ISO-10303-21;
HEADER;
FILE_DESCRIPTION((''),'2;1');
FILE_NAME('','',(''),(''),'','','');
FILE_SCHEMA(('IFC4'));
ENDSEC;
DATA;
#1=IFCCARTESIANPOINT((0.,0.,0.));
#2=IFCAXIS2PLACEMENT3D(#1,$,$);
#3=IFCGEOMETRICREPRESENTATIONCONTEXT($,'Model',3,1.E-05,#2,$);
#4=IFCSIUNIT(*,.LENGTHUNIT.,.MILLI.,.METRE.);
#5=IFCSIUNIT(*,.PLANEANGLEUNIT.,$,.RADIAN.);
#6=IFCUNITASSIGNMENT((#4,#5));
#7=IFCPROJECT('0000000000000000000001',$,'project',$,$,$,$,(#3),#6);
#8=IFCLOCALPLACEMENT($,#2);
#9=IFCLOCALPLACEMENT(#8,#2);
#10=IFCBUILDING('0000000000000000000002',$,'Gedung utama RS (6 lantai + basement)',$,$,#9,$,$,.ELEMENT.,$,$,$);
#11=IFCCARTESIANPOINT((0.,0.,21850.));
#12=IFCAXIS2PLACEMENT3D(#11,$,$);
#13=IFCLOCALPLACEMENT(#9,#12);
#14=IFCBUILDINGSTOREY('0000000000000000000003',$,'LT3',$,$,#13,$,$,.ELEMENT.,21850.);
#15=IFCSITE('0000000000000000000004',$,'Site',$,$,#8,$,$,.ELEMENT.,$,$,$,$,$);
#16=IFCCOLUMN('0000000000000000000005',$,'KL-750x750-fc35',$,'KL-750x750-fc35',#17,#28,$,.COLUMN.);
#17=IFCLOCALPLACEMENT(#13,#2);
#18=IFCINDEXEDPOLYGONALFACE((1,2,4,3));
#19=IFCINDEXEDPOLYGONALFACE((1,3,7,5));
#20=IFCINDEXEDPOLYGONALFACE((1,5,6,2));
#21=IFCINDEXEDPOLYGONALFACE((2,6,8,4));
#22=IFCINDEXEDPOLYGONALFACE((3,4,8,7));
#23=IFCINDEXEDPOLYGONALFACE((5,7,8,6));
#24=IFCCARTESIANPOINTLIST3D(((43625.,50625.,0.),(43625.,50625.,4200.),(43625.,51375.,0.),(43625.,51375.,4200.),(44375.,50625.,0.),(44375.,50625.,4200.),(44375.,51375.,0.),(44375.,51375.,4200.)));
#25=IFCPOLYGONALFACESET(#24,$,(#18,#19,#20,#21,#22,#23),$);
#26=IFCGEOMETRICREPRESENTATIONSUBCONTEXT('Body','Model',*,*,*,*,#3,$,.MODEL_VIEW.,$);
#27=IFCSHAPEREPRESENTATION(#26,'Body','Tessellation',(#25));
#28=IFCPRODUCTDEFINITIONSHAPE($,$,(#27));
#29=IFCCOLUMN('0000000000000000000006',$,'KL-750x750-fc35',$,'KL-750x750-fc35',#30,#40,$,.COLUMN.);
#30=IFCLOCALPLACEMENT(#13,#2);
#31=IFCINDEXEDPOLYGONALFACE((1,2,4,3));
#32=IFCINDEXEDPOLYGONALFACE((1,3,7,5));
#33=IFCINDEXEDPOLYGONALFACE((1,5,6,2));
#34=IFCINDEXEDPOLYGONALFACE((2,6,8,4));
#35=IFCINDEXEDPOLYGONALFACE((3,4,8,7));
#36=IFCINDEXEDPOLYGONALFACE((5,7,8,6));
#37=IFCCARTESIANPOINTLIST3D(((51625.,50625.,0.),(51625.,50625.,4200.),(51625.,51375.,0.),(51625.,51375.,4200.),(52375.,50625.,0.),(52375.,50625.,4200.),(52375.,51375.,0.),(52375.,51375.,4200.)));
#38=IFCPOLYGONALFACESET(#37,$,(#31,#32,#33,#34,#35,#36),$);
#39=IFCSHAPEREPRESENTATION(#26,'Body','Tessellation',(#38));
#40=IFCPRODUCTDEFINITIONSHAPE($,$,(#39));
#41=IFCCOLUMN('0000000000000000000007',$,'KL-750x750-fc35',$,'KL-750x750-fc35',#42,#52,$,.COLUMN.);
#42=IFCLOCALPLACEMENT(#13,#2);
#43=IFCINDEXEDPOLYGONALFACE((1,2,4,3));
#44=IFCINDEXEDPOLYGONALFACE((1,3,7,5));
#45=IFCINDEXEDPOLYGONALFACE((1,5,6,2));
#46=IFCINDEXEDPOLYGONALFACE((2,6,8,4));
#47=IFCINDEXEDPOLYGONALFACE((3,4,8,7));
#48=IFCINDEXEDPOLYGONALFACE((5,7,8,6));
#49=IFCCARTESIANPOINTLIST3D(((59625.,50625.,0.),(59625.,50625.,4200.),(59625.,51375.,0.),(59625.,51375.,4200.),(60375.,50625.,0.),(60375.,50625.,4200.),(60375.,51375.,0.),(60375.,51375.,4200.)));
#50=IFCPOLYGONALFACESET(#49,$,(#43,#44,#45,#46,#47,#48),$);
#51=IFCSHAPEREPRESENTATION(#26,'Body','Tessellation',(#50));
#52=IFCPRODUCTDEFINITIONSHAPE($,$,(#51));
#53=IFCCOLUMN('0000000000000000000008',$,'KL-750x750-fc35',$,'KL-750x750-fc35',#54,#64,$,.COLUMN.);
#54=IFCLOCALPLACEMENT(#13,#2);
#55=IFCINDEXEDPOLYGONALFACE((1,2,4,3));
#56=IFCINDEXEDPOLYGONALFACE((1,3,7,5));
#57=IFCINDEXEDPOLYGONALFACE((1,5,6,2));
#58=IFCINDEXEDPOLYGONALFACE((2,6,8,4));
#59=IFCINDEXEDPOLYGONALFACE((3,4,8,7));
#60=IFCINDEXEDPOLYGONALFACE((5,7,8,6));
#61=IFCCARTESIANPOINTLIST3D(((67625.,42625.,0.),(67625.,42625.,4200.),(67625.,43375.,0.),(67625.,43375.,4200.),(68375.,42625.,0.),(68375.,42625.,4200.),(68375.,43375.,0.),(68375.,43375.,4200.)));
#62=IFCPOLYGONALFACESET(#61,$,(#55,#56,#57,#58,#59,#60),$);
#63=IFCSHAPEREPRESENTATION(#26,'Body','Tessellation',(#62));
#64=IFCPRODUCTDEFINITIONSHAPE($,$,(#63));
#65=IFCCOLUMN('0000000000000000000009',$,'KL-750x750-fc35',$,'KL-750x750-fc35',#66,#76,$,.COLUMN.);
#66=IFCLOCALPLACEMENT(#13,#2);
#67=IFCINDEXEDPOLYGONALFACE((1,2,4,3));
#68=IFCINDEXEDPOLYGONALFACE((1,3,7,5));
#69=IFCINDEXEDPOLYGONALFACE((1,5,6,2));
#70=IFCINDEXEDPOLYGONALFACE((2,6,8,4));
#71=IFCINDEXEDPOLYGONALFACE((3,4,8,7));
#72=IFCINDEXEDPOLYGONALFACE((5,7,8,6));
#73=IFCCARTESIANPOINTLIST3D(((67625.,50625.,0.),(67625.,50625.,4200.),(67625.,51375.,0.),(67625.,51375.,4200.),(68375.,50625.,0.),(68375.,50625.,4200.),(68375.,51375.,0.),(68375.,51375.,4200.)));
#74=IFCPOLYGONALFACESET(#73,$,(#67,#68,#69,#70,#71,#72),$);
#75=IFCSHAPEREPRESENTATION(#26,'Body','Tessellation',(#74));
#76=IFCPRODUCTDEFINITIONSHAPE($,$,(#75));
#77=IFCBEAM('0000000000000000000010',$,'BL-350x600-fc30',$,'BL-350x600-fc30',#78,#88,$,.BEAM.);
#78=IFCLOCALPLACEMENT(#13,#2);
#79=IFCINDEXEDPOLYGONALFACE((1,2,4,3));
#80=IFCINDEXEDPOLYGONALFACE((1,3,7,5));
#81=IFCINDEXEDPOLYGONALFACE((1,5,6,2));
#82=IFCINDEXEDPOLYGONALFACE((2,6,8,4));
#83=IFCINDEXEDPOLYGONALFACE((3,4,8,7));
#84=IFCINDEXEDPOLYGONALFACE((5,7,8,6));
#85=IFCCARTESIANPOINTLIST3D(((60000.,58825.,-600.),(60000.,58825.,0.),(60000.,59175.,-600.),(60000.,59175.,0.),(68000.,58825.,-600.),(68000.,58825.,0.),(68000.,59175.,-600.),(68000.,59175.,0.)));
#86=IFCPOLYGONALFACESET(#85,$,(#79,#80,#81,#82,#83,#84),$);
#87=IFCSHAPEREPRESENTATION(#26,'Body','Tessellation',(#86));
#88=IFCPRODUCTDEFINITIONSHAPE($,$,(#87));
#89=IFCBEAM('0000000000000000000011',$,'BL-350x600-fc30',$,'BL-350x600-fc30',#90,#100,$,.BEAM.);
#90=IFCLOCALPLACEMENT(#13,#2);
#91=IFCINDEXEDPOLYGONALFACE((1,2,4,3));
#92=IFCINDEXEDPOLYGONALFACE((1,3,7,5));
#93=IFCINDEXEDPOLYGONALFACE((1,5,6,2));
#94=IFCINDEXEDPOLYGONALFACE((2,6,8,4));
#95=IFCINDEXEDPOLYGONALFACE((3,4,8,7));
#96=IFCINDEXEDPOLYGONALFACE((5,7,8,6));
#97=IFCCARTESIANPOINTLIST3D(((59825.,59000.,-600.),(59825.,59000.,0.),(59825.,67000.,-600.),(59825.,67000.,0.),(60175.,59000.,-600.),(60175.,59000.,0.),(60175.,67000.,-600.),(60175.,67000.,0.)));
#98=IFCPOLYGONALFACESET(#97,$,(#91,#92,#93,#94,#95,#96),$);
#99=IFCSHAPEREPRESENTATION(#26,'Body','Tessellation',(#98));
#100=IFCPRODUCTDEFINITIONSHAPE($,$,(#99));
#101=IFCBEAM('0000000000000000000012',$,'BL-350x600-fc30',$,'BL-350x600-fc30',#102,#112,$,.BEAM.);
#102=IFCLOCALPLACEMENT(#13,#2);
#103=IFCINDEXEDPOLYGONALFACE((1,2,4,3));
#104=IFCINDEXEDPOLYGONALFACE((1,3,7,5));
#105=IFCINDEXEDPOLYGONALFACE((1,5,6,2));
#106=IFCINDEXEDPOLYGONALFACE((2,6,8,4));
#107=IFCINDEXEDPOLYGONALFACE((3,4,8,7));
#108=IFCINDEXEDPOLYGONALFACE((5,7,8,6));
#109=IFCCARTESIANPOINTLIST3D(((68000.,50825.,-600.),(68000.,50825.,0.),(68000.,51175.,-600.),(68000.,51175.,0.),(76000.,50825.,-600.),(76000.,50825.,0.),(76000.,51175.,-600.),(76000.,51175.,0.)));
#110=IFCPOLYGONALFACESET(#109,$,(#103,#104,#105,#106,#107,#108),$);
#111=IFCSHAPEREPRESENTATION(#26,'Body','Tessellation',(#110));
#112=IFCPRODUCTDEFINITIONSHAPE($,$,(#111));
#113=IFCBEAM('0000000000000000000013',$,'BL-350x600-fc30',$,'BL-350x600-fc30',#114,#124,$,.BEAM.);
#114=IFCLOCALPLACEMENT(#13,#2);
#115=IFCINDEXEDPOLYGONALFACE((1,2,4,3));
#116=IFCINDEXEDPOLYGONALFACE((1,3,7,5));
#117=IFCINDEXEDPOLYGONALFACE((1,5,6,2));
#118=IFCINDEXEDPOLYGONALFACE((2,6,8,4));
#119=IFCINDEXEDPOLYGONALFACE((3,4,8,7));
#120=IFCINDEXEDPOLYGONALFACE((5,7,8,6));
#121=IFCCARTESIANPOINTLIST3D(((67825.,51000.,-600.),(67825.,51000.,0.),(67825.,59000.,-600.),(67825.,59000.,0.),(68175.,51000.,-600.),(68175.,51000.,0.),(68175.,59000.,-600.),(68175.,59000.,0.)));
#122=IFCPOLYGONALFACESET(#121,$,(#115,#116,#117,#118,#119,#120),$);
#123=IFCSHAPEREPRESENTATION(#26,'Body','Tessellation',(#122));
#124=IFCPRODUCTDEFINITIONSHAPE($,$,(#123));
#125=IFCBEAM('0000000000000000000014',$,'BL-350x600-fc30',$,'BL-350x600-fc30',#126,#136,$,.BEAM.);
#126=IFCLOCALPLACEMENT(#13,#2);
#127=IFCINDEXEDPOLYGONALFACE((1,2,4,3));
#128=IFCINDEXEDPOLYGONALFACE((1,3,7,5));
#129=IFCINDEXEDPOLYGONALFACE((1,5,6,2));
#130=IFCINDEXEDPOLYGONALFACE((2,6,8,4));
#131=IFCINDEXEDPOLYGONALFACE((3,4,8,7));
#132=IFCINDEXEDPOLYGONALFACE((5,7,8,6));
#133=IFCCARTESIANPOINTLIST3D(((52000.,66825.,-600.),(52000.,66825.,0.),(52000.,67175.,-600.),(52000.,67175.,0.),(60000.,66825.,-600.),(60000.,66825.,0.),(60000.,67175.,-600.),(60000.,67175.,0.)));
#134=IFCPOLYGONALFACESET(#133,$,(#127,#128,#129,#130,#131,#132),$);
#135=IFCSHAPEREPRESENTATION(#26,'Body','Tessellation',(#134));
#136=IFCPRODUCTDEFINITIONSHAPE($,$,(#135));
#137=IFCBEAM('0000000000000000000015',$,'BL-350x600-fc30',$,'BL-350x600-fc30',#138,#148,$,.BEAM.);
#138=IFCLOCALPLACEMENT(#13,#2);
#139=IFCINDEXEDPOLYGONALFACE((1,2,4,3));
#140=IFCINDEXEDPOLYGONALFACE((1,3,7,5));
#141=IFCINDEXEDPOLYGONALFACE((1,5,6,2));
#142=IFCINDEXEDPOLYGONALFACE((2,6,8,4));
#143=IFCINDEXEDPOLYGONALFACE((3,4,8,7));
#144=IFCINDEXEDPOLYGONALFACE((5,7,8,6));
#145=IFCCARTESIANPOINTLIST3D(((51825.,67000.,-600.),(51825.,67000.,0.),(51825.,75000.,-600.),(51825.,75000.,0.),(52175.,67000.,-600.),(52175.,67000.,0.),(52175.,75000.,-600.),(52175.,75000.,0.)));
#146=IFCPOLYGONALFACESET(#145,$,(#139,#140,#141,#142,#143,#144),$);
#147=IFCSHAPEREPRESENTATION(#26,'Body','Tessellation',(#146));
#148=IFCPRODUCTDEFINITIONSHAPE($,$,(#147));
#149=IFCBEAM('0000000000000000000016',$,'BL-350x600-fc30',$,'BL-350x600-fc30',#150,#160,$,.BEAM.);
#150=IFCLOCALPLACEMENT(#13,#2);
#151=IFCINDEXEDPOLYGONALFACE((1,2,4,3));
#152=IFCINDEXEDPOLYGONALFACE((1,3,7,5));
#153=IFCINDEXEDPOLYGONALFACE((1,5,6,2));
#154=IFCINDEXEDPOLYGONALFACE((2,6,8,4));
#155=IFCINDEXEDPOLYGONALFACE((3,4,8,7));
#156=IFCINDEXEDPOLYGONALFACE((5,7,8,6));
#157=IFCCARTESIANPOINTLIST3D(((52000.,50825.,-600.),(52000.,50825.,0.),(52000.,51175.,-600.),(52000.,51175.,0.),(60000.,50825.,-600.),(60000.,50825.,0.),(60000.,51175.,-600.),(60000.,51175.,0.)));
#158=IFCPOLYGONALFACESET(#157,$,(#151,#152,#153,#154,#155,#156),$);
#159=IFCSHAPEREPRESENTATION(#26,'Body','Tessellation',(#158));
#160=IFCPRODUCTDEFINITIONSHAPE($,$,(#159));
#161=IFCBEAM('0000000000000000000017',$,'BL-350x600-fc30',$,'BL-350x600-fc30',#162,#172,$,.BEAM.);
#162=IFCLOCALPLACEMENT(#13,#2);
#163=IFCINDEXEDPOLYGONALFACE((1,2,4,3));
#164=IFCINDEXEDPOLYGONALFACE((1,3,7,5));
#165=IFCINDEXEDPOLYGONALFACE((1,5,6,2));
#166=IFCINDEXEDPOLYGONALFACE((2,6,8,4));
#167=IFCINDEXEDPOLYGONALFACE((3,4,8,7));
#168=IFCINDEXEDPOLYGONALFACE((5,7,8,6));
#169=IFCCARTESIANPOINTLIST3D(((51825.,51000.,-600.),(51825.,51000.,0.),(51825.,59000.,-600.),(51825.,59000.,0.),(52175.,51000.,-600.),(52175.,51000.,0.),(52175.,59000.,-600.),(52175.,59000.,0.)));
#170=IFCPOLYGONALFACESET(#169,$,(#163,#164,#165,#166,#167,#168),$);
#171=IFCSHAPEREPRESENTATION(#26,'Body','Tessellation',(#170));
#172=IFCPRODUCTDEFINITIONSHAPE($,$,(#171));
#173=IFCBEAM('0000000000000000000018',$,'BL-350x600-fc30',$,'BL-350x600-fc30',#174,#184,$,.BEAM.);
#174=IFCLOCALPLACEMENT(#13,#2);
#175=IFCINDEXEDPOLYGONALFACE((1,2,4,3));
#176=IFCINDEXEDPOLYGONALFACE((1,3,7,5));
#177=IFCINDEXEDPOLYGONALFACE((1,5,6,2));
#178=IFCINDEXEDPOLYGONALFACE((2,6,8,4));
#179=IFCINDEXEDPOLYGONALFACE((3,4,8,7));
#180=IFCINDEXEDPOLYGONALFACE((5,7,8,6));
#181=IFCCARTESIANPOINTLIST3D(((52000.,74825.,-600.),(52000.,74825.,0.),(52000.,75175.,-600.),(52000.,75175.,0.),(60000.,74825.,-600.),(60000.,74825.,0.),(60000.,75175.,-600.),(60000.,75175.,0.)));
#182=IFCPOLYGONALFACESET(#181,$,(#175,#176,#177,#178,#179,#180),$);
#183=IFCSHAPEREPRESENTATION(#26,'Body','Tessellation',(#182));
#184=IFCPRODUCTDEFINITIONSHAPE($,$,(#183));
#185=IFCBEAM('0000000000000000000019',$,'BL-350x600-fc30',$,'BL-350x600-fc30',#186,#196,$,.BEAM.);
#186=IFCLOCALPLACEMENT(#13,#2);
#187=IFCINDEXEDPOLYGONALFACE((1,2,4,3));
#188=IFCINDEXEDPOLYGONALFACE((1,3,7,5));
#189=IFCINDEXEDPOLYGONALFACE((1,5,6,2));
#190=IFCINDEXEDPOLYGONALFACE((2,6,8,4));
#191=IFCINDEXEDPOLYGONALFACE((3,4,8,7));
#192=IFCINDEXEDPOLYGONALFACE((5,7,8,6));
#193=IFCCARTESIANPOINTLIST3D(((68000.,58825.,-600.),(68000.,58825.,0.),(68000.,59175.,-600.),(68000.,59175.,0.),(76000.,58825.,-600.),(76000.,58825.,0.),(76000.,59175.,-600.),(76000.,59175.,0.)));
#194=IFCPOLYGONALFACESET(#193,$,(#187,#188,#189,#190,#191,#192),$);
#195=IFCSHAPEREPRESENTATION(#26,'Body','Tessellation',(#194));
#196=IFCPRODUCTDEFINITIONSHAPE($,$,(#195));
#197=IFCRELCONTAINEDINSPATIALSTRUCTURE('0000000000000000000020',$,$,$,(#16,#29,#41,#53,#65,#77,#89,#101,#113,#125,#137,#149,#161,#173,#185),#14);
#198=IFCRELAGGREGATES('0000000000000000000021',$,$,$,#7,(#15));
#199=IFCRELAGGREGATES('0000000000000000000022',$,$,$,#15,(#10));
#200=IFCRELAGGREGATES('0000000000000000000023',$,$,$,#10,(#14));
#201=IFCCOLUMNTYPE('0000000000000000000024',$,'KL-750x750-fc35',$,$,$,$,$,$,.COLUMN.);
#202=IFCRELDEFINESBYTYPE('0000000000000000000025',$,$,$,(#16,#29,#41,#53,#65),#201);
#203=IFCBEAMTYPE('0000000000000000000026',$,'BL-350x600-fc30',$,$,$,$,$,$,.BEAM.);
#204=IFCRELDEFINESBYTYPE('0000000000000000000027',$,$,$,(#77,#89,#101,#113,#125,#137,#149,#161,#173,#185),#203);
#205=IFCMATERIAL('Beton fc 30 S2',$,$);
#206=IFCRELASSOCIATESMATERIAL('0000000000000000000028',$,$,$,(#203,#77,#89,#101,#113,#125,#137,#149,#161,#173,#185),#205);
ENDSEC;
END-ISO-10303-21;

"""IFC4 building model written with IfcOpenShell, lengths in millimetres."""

from ifc_helpers import new_model, si_unit, frame, origin, origin_2d, place, context, subcontext, project, spatial, rectangle, extrude, material, material_profile, profile_set, profile_usage, type_object, element, save


model = new_model("IFC4")

# Units and contexts
model_context = context("Model", 3, precision=1e-05, world=origin())
body_context = subcontext(model_context, "Body", "Model", "MODEL_VIEW")
ifc_project = project(units=[si_unit("LENGTHUNIT", "METRE", prefix="MILLI"), si_unit("PLANEANGLEUNIT", "RADIAN")], contexts=[model_context])

# Site, building, storey
site_placement = place(None, origin())
site = spatial("IfcSite", under=ifc_project, at=site_placement, Name="Site", CompositionType="ELEMENT")
building_placement = place(site_placement, origin())
building = spatial("IfcBuilding", under=site, at=building_placement, Name="Gedung utama RS (6 lantai + basement)", CompositionType="ELEMENT")
storey_placement = place(building_placement, frame((0.0, 0.0, 21850.0)))
storey = spatial("IfcBuildingStorey", under=building, at=storey_placement, Name="LT3", CompositionType="ELEMENT", Elevation=21850.0)

# Columns
ifc_material_profile_1 = material_profile(None, rectangle(XDim=750.0, YDim=750.0, at=origin_2d()), Name="KL-750x750-fc35")
ifc_profile_set_1 = profile_set([ifc_material_profile_1], Name="KL-750x750-fc35")
ifc_profile_usage_1 = profile_usage(ifc_profile_set_1, cardinal=5)
column_type = type_object("IfcColumnType", Name="KL-750x750-fc35", PredefinedType="COLUMN", material=ifc_profile_set_1)
for number, where, z_axis, x_axis, name in (
    (1, (44000.0, 51000.0, 0.0), (0.0, 0.0, 1.0), (1.0, 0.0, 0.0), "KL-750x750-fc35"),
    (2, (52000.0, 51000.0, 0.0), (0.0, 0.0, 1.0), (1.0, 0.0, 0.0), "KL-750x750-fc35"),
    (3, (60000.0, 51000.0, 0.0), (0.0, 0.0, 1.0), (1.0, 0.0, 0.0), "KL-750x750-fc35"),
    (4, (68000.0, 43000.0, 0.0), (0.0, 0.0, 1.0), (1.0, 0.0, 0.0), "KL-750x750-fc35"),
    (5, (68000.0, 51000.0, 0.0), (0.0, 0.0, 1.0), (1.0, 0.0, 0.0), "KL-750x750-fc35"),
):
    element("IfcColumn", number, at=place(storey_placement, frame(where, z_axis=z_axis, x_axis=x_axis)), inside=storey, type_object=column_type, material=ifc_profile_usage_1, Name=name, ObjectType="KL-750x750-fc35", PredefinedType="COLUMN", context=body_context, shape_type="SweptSolid", body=[
        extrude(rectangle(XDim=750.0, YDim=750.0, at=origin_2d()), origin(), (0.0, 0.0, 1.0), 4200.0),
    ])

# Beams
ifc_material = material(Name="Beton fc 30 S2")
ifc_material_profile_2 = material_profile(ifc_material, rectangle(XDim=350.0, YDim=600.0, at=origin_2d()), Name="BL-350x600-fc30")
ifc_profile_set_2 = profile_set([ifc_material_profile_2], Name="BL-350x600-fc30")
ifc_profile_usage_2 = profile_usage(ifc_profile_set_2, cardinal=8)
beam_type_1 = type_object("IfcBeamType", Name="BL-350x600-fc30", PredefinedType="BEAM", material=ifc_profile_set_2)
beam_1_placement = place(storey_placement, frame((60000.0, 59000.0, -300.0)))
element("IfcBeam", 6, at=beam_1_placement, inside=storey, type_object=beam_type_1, material=ifc_profile_usage_2, Name="BL-350x600-fc30", ObjectType="BL-350x600-fc30", PredefinedType="BEAM", context=body_context, shape_type="SweptSolid", body=[
    extrude(rectangle(XDim=350.0, YDim=600.0, at=origin_2d()), frame((0.0, 0.0, 0.0), z_axis=(1.0, 0.0, 0.0), x_axis=(0.0, 1.0, 0.0)), (0.0, 0.0, 1.0), 8000.0),
])
beam_2_placement = place(storey_placement, frame((60000.0, 59000.0, -300.0)))
element("IfcBeam", 7, at=beam_2_placement, inside=storey, type_object=beam_type_1, material=ifc_profile_usage_2, Name="BL-350x600-fc30", ObjectType="BL-350x600-fc30", PredefinedType="BEAM", context=body_context, shape_type="SweptSolid", body=[
    extrude(rectangle(XDim=350.0, YDim=600.0, at=origin_2d()), frame((0.0, 0.0, 0.0), z_axis=(0.0, 1.0, 0.0), x_axis=(-1.0, 0.0, 0.0)), (0.0, 0.0, 1.0), 8000.0),
])
beam_3_placement = place(storey_placement, frame((68000.0, 51000.0, -300.0)))
element("IfcBeam", 8, at=beam_3_placement, inside=storey, type_object=beam_type_1, material=ifc_profile_usage_2, Name="BL-350x600-fc30", ObjectType="BL-350x600-fc30", PredefinedType="BEAM", context=body_context, shape_type="SweptSolid", body=[
    extrude(rectangle(XDim=350.0, YDim=600.0, at=origin_2d()), frame((0.0, 0.0, 0.0), z_axis=(1.0, 0.0, 0.0), x_axis=(0.0, 1.0, 0.0)), (0.0, 0.0, 1.0), 8000.0),
])
beam_4_placement = place(storey_placement, frame((68000.0, 51000.0, -300.0)))
element("IfcBeam", 9, at=beam_4_placement, inside=storey, type_object=beam_type_1, material=ifc_profile_usage_2, Name="BL-350x600-fc30", ObjectType="BL-350x600-fc30", PredefinedType="BEAM", context=body_context, shape_type="SweptSolid", body=[
    extrude(rectangle(XDim=350.0, YDim=600.0, at=origin_2d()), frame((0.0, 0.0, 0.0), z_axis=(0.0, 1.0, 0.0), x_axis=(-1.0, 0.0, 0.0)), (0.0, 0.0, 1.0), 8000.0),
])
beam_5_placement = place(storey_placement, frame((52000.0, 67000.0, -300.0)))
element("IfcBeam", 10, at=beam_5_placement, inside=storey, type_object=beam_type_1, material=ifc_profile_usage_2, Name="BL-350x600-fc30", ObjectType="BL-350x600-fc30", PredefinedType="BEAM", context=body_context, shape_type="SweptSolid", body=[
    extrude(rectangle(XDim=350.0, YDim=600.0, at=origin_2d()), frame((0.0, 0.0, 0.0), z_axis=(1.0, 0.0, 0.0), x_axis=(0.0, 1.0, 0.0)), (0.0, 0.0, 1.0), 8000.0),
])
beam_6_placement = place(storey_placement, frame((52000.0, 67000.0, -300.0)))
element("IfcBeam", 11, at=beam_6_placement, inside=storey, type_object=beam_type_1, material=ifc_profile_usage_2, Name="BL-350x600-fc30", ObjectType="BL-350x600-fc30", PredefinedType="BEAM", context=body_context, shape_type="SweptSolid", body=[
    extrude(rectangle(XDim=350.0, YDim=600.0, at=origin_2d()), frame((0.0, 0.0, 0.0), z_axis=(0.0, 1.0, 0.0), x_axis=(-1.0, 0.0, 0.0)), (0.0, 0.0, 1.0), 8000.0),
])
beam_7_placement = place(storey_placement, frame((52000.0, 51000.0, -300.0)))
element("IfcBeam", 12, at=beam_7_placement, inside=storey, type_object=beam_type_1, material=ifc_profile_usage_2, Name="BL-350x600-fc30", ObjectType="BL-350x600-fc30", PredefinedType="BEAM", context=body_context, shape_type="SweptSolid", body=[
    extrude(rectangle(XDim=350.0, YDim=600.0, at=origin_2d()), frame((0.0, 0.0, 0.0), z_axis=(1.0, 0.0, 0.0), x_axis=(0.0, 1.0, 0.0)), (0.0, 0.0, 1.0), 8000.0),
])
beam_8_placement = place(storey_placement, frame((52000.0, 51000.0, -300.0)))
element("IfcBeam", 13, at=beam_8_placement, inside=storey, type_object=beam_type_1, material=ifc_profile_usage_2, Name="BL-350x600-fc30", ObjectType="BL-350x600-fc30", PredefinedType="BEAM", context=body_context, shape_type="SweptSolid", body=[
    extrude(rectangle(XDim=350.0, YDim=600.0, at=origin_2d()), frame((0.0, 0.0, 0.0), z_axis=(0.0, 1.0, 0.0), x_axis=(-1.0, 0.0, 0.0)), (0.0, 0.0, 1.0), 8000.0),
])
for number, where, name in (
    (14, (52000.0, 75000.0, -300.0), "BL-350x600-fc30"),
    (15, (68000.0, 59000.0, -300.0), "BL-350x600-fc30"),
):
    element("IfcBeam", number, at=place(storey_placement, frame(where)), inside=storey, type_object=beam_type_1, material=ifc_profile_usage_2, Name=name, ObjectType="BL-350x600-fc30", PredefinedType="BEAM", context=body_context, shape_type="SweptSolid", body=[
        extrude(rectangle(XDim=350.0, YDim=600.0, at=origin_2d()), frame((0.0, 0.0, 0.0), z_axis=(1.0, 0.0, 0.0), x_axis=(0.0, 1.0, 0.0)), (0.0, 0.0, 1.0), 8000.0),
    ])

save(model, "model.ifc")
